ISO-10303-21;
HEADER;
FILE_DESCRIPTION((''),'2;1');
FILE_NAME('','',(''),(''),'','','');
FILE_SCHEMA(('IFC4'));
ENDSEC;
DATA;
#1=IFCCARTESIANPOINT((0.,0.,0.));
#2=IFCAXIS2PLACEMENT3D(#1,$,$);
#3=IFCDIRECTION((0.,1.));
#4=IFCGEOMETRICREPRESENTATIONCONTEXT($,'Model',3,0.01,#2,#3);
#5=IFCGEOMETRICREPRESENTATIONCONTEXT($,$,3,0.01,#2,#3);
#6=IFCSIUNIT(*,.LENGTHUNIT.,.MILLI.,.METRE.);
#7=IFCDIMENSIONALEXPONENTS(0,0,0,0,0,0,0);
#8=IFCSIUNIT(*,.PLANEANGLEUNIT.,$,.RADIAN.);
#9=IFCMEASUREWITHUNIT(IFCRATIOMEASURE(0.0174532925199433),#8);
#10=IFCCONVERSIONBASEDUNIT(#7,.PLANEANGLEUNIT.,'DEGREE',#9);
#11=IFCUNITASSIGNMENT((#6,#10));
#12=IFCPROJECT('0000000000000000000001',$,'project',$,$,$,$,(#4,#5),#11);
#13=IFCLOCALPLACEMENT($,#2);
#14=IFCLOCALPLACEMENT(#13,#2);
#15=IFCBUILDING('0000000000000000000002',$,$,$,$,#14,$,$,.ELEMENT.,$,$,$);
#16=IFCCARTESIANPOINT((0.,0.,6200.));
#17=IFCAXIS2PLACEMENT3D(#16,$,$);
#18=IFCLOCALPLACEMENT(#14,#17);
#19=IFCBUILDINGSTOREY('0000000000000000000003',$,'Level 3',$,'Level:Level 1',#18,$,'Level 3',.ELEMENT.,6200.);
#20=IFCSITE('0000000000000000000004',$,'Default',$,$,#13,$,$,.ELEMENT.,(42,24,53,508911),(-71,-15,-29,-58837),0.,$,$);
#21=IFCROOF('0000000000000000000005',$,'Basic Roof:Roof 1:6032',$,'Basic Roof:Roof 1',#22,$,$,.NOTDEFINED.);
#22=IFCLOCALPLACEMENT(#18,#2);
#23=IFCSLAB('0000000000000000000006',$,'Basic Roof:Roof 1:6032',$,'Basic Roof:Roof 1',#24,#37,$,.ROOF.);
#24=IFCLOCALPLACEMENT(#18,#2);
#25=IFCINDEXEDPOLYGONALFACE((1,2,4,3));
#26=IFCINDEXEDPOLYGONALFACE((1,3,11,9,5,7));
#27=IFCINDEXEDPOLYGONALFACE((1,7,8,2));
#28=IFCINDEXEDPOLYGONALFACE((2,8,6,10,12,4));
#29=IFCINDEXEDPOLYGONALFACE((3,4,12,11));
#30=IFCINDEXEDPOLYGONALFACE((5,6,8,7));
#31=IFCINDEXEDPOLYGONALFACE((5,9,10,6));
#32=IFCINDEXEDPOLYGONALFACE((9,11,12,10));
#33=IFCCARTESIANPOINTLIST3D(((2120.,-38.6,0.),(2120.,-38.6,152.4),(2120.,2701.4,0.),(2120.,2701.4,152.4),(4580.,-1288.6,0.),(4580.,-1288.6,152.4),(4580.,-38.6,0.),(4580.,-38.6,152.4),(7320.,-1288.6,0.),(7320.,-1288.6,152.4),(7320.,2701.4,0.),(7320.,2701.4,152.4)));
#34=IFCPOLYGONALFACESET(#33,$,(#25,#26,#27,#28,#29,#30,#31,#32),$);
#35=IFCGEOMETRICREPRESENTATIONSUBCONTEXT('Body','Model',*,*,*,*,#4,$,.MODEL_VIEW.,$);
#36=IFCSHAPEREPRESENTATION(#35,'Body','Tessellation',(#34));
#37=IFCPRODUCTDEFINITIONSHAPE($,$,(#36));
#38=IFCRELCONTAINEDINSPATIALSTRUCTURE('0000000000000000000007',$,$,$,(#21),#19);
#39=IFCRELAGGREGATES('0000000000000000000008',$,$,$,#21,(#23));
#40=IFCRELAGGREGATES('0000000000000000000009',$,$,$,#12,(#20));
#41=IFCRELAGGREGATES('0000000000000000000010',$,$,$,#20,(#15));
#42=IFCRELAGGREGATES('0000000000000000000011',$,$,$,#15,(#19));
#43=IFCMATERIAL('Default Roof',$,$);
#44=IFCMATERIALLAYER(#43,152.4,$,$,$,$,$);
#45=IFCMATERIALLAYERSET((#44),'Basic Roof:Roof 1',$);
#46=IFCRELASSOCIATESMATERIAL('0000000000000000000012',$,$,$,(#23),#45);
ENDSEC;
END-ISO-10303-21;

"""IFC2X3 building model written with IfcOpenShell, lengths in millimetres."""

from ifc_helpers import new_model, entity, si_unit, converted_unit, direction, frame, origin, place, context, subcontext, project, spatial, polyline, outline, extrude, material, layer, layer_set, element, aggregate, save


model = new_model("IFC2X3")

# Units and contexts
model_context = context("Model", 3, precision=0.01, world=origin(), true_north=direction((0.0, 1.0)))
context_of_model = context(None, 3, precision=0.01, world=origin(), true_north=direction((0.0, 1.0)))
body_context = subcontext(model_context, "Body", "Model", "MODEL_VIEW")
ifc_project = project(units=[si_unit("LENGTHUNIT", "METRE", prefix="MILLI"), converted_unit("PLANEANGLEUNIT", "DEGREE", entity("IfcRatioMeasure", 0.0174532925199433), si_unit("PLANEANGLEUNIT", "RADIAN"), dimensions=[0, 0, 0, 0, 0, 0, 0])], contexts=[model_context, context_of_model])

# Site, building, storey
site_placement = place(None, origin())
site = spatial("IfcSite", under=ifc_project, at=site_placement, Name="Default", CompositionType="ELEMENT", RefLatitude=(42, 24, 53, 508911), RefLongitude=(-71, -15, -29, -58837), RefElevation=0.0)
building_placement = place(site_placement, origin())
building = spatial("IfcBuilding", under=site, at=building_placement, CompositionType="ELEMENT")
storey_placement = place(building_placement, frame((0.0, 0.0, 6200.0)))
storey = spatial("IfcBuildingStorey", under=building, at=storey_placement, Name="Level 3", ObjectType="Level:Level 1", LongName="Level 3", CompositionType="ELEMENT", Elevation=6200.0)

# Roof, slab
roof_placement = place(storey_placement, frame((2120.0, -1288.6, 0.0)))
roof = element("IfcRoof", 1, at=roof_placement, inside=storey, Name="Basic Roof:Roof 1:6032", ObjectType="Basic Roof:Roof 1", ShapeType="NOTDEFINED")
ifc_material = material(Name="Default Roof")
ifc_layer = layer(ifc_material, 152.4)
ifc_layer_set = layer_set([ifc_layer], Name="Basic Roof:Roof 1")
slab_placement = place(roof_placement, origin())
slab = element("IfcSlab", 2, at=slab_placement, material=ifc_layer_set, Name="Basic Roof:Roof 1:6032", ObjectType="Basic Roof:Roof 1", PredefinedType="ROOF", context=body_context, shape_type="SweptSolid", body=[
    extrude(outline(polyline([(-2600.0, 1995.0), (-2600.0, -745.0), (-140.0, -745.0), (-140.0, -1995.0), (2600.0, -1995.0), (2600.0, 1995.0), (-2600.0, 1995.0)])), frame((2600.0, 1995.0, 0.0)), (0.0, 0.0, 1.0), 152.4),
])
aggregate(roof, [slab])

save(model, "model.ifc")
